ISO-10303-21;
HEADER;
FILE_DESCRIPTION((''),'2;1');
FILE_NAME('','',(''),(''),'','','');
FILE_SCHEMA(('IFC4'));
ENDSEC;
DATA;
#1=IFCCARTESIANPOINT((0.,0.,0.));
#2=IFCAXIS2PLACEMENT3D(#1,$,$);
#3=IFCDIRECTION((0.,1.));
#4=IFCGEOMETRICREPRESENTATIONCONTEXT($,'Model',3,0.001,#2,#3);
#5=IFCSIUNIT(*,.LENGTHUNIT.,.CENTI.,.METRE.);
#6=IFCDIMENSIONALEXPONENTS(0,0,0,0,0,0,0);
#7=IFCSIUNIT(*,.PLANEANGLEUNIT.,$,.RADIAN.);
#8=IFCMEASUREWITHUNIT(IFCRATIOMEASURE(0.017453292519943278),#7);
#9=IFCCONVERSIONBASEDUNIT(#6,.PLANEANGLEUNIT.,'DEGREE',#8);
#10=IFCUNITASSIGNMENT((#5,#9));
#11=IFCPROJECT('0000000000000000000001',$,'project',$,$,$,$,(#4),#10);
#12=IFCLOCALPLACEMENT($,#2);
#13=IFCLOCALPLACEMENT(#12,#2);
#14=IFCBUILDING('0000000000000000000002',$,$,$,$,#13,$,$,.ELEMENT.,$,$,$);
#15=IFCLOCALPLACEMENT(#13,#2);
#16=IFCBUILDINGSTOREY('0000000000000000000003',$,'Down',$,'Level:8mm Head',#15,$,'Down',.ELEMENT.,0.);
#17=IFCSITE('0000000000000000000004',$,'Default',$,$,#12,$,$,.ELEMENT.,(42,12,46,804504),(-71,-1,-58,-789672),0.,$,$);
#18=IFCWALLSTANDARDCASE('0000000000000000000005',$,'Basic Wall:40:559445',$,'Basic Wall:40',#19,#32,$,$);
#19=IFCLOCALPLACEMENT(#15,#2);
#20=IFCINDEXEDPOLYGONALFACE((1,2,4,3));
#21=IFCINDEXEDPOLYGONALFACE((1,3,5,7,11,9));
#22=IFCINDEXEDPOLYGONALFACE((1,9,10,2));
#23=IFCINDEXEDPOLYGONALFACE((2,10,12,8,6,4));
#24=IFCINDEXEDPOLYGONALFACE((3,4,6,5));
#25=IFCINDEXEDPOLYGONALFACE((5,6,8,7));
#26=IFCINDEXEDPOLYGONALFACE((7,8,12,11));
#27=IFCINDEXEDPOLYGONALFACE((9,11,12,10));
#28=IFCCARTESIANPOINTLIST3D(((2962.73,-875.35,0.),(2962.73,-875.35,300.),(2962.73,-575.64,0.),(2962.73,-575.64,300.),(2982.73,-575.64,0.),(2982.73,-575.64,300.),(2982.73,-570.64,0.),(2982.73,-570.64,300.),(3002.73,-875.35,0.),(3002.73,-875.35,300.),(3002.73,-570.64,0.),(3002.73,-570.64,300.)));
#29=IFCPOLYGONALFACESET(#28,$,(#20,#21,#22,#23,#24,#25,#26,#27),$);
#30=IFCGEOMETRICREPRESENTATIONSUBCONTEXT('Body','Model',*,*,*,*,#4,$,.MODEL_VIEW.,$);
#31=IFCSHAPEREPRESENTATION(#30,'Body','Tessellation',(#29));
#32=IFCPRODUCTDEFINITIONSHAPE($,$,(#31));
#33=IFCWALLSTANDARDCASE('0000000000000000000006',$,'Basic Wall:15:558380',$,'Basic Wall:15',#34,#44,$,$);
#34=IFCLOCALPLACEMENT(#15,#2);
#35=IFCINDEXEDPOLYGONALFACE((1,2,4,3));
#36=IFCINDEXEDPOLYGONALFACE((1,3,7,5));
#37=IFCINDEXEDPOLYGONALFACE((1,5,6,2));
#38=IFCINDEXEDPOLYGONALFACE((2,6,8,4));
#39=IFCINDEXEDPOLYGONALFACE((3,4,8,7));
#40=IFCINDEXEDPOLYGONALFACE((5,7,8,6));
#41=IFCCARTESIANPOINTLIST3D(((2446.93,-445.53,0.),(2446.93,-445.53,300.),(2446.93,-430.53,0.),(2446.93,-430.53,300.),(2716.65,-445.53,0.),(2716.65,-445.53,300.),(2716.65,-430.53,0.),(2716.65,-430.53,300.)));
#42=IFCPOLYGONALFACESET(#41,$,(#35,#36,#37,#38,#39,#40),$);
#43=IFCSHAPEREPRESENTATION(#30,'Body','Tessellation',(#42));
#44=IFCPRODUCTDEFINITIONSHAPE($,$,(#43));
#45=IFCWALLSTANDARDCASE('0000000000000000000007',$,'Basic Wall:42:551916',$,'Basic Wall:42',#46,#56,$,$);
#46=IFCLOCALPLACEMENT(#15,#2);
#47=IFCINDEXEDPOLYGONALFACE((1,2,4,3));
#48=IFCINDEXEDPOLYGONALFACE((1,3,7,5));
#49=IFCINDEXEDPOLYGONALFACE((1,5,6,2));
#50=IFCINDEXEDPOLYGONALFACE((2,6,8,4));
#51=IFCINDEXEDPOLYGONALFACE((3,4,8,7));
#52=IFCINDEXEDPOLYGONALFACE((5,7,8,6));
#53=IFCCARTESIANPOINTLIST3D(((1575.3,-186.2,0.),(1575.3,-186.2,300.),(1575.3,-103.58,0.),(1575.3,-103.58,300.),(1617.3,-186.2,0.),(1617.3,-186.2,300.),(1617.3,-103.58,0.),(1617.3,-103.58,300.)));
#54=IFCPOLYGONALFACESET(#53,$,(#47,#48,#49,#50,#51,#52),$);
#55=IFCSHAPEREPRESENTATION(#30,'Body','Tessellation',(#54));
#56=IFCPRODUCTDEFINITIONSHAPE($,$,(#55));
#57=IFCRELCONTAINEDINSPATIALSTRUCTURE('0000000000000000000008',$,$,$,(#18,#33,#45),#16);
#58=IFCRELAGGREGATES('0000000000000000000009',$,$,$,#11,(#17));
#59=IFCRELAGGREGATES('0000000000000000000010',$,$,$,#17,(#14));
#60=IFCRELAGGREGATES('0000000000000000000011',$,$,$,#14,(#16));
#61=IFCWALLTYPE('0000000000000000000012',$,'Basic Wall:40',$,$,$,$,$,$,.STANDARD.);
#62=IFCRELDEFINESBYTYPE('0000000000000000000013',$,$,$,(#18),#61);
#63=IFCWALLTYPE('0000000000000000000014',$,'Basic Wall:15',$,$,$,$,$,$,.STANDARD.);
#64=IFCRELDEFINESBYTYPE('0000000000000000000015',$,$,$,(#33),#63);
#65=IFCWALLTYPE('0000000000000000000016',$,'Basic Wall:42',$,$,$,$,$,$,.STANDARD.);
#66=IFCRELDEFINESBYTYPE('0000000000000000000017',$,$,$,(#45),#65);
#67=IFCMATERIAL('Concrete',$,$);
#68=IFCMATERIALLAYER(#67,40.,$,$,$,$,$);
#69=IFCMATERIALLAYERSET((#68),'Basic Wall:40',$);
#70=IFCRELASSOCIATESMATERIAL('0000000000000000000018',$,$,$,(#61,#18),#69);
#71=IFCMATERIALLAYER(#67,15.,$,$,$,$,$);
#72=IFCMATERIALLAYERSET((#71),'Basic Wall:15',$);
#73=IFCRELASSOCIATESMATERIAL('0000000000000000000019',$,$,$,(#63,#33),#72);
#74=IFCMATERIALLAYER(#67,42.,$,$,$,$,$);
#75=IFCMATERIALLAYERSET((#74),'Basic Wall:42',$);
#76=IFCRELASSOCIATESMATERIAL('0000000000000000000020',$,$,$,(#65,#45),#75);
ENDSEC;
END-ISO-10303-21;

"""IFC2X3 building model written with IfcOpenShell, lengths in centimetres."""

from ifc_helpers import new_model, entity, si_unit, converted_unit, direction, frame, frame_2d, origin, place, context, subcontext, project, spatial, polyline, rectangle, outline, extrude, material, layer, layer_set, layer_usage, type_object, element, save


model = new_model("IFC2X3")

# Units and contexts
model_context = context("Model", 3, precision=0.001, world=origin(), true_north=direction((0.0, 1.0)))
body_context = subcontext(model_context, "Body", "Model", "MODEL_VIEW")
ifc_project = project(units=[si_unit("LENGTHUNIT", "METRE", prefix="CENTI"), converted_unit("PLANEANGLEUNIT", "DEGREE", entity("IfcRatioMeasure", 0.017453292519943278), si_unit("PLANEANGLEUNIT", "RADIAN"), dimensions=[0, 0, 0, 0, 0, 0, 0])], contexts=[model_context])

# Site, building, storey
site_placement = place(None, origin())
site = spatial("IfcSite", under=ifc_project, at=site_placement, Name="Default", CompositionType="ELEMENT", RefLatitude=(42, 12, 46, 804504), RefLongitude=(-71, -1, -58, -789672), RefElevation=0.0)
building_placement = place(site_placement, origin())
building = spatial("IfcBuilding", under=site, at=building_placement, CompositionType="ELEMENT")
storey_placement = place(building_placement, origin())
storey = spatial("IfcBuildingStorey", under=building, at=storey_placement, Name="Down", ObjectType="Level:8mm Head", LongName="Down", CompositionType="ELEMENT", Elevation=0.0)

# Walls
ifc_material = material(Name="Concrete")
ifc_layer_1 = layer(ifc_material, 40.0)
ifc_layer_set_1 = layer_set([ifc_layer_1], Name="Basic Wall:40")
ifc_layer_usage_1 = layer_usage(ifc_layer_set_1, "AXIS2", "POSITIVE", -20.0)
wall_type_1 = type_object("IfcWallType", Name="Basic Wall:40", PredefinedType="STANDARD", material=ifc_layer_set_1)
wall_1_placement = place(storey_placement, frame((2982.73, -875.35, 0.0), z_axis=(0.0, 0.0, 1.0), x_axis=(0.0, 1.0, 0.0)))
element("IfcWallStandardCase", 1, at=wall_1_placement, inside=storey, type_object=wall_type_1, material=ifc_layer_usage_1, Name="Basic Wall:40:559445", ObjectType="Basic Wall:40", context=body_context, shape_type="SweptSolid", body=[
    extrude(outline(polyline([(304.71, -20.0), (304.71, 0.0), (299.71, 0.0), (299.71, 20.0), (0.0, 20.0), (0.0, -20.0), (304.71, -20.0)])), origin(), (0.0, 0.0, 1.0), 300.0),
])
ifc_layer_2 = layer(ifc_material, 15.0)
ifc_layer_set_2 = layer_set([ifc_layer_2], Name="Basic Wall:15")
ifc_layer_usage_2 = layer_usage(ifc_layer_set_2, "AXIS2", "NEGATIVE", 7.5)
wall_type_2 = type_object("IfcWallType", Name="Basic Wall:15", PredefinedType="STANDARD", material=ifc_layer_set_2)
wall_2_placement = place(storey_placement, frame((2446.93, -438.03, 0.0)))
element("IfcWallStandardCase", 2, at=wall_2_placement, inside=storey, type_object=wall_type_2, material=ifc_layer_usage_2, Name="Basic Wall:15:558380", ObjectType="Basic Wall:15", context=body_context, shape_type="SweptSolid", body=[
    extrude(rectangle(XDim=269.71, YDim=15.0, at=frame_2d((134.86, 0.0), x_axis=(-1.0, 0.0))), origin(), (0.0, 0.0, 1.0), 300.0),
])
ifc_layer_3 = layer(ifc_material, 42.0)
ifc_layer_set_3 = layer_set([ifc_layer_3], Name="Basic Wall:42")
ifc_layer_usage_3 = layer_usage(ifc_layer_set_3, "AXIS2", "NEGATIVE", 21.0)
wall_type_3 = type_object("IfcWallType", Name="Basic Wall:42", PredefinedType="STANDARD", material=ifc_layer_set_3)
wall_3_placement = place(storey_placement, frame((1596.3, -103.58, 0.0), z_axis=(0.0, 0.0, 1.0), x_axis=(0.0, -1.0, 0.0)))
element("IfcWallStandardCase", 3, at=wall_3_placement, inside=storey, type_object=wall_type_3, material=ifc_layer_usage_3, Name="Basic Wall:42:551916", ObjectType="Basic Wall:42", context=body_context, shape_type="SweptSolid", body=[
    extrude(rectangle(XDim=82.62, YDim=42.0, at=frame_2d((41.31, 0.0), x_axis=(-1.0, 0.0))), origin(), (0.0, 0.0, 1.0), 300.0),
])

save(model, "model.ifc")
